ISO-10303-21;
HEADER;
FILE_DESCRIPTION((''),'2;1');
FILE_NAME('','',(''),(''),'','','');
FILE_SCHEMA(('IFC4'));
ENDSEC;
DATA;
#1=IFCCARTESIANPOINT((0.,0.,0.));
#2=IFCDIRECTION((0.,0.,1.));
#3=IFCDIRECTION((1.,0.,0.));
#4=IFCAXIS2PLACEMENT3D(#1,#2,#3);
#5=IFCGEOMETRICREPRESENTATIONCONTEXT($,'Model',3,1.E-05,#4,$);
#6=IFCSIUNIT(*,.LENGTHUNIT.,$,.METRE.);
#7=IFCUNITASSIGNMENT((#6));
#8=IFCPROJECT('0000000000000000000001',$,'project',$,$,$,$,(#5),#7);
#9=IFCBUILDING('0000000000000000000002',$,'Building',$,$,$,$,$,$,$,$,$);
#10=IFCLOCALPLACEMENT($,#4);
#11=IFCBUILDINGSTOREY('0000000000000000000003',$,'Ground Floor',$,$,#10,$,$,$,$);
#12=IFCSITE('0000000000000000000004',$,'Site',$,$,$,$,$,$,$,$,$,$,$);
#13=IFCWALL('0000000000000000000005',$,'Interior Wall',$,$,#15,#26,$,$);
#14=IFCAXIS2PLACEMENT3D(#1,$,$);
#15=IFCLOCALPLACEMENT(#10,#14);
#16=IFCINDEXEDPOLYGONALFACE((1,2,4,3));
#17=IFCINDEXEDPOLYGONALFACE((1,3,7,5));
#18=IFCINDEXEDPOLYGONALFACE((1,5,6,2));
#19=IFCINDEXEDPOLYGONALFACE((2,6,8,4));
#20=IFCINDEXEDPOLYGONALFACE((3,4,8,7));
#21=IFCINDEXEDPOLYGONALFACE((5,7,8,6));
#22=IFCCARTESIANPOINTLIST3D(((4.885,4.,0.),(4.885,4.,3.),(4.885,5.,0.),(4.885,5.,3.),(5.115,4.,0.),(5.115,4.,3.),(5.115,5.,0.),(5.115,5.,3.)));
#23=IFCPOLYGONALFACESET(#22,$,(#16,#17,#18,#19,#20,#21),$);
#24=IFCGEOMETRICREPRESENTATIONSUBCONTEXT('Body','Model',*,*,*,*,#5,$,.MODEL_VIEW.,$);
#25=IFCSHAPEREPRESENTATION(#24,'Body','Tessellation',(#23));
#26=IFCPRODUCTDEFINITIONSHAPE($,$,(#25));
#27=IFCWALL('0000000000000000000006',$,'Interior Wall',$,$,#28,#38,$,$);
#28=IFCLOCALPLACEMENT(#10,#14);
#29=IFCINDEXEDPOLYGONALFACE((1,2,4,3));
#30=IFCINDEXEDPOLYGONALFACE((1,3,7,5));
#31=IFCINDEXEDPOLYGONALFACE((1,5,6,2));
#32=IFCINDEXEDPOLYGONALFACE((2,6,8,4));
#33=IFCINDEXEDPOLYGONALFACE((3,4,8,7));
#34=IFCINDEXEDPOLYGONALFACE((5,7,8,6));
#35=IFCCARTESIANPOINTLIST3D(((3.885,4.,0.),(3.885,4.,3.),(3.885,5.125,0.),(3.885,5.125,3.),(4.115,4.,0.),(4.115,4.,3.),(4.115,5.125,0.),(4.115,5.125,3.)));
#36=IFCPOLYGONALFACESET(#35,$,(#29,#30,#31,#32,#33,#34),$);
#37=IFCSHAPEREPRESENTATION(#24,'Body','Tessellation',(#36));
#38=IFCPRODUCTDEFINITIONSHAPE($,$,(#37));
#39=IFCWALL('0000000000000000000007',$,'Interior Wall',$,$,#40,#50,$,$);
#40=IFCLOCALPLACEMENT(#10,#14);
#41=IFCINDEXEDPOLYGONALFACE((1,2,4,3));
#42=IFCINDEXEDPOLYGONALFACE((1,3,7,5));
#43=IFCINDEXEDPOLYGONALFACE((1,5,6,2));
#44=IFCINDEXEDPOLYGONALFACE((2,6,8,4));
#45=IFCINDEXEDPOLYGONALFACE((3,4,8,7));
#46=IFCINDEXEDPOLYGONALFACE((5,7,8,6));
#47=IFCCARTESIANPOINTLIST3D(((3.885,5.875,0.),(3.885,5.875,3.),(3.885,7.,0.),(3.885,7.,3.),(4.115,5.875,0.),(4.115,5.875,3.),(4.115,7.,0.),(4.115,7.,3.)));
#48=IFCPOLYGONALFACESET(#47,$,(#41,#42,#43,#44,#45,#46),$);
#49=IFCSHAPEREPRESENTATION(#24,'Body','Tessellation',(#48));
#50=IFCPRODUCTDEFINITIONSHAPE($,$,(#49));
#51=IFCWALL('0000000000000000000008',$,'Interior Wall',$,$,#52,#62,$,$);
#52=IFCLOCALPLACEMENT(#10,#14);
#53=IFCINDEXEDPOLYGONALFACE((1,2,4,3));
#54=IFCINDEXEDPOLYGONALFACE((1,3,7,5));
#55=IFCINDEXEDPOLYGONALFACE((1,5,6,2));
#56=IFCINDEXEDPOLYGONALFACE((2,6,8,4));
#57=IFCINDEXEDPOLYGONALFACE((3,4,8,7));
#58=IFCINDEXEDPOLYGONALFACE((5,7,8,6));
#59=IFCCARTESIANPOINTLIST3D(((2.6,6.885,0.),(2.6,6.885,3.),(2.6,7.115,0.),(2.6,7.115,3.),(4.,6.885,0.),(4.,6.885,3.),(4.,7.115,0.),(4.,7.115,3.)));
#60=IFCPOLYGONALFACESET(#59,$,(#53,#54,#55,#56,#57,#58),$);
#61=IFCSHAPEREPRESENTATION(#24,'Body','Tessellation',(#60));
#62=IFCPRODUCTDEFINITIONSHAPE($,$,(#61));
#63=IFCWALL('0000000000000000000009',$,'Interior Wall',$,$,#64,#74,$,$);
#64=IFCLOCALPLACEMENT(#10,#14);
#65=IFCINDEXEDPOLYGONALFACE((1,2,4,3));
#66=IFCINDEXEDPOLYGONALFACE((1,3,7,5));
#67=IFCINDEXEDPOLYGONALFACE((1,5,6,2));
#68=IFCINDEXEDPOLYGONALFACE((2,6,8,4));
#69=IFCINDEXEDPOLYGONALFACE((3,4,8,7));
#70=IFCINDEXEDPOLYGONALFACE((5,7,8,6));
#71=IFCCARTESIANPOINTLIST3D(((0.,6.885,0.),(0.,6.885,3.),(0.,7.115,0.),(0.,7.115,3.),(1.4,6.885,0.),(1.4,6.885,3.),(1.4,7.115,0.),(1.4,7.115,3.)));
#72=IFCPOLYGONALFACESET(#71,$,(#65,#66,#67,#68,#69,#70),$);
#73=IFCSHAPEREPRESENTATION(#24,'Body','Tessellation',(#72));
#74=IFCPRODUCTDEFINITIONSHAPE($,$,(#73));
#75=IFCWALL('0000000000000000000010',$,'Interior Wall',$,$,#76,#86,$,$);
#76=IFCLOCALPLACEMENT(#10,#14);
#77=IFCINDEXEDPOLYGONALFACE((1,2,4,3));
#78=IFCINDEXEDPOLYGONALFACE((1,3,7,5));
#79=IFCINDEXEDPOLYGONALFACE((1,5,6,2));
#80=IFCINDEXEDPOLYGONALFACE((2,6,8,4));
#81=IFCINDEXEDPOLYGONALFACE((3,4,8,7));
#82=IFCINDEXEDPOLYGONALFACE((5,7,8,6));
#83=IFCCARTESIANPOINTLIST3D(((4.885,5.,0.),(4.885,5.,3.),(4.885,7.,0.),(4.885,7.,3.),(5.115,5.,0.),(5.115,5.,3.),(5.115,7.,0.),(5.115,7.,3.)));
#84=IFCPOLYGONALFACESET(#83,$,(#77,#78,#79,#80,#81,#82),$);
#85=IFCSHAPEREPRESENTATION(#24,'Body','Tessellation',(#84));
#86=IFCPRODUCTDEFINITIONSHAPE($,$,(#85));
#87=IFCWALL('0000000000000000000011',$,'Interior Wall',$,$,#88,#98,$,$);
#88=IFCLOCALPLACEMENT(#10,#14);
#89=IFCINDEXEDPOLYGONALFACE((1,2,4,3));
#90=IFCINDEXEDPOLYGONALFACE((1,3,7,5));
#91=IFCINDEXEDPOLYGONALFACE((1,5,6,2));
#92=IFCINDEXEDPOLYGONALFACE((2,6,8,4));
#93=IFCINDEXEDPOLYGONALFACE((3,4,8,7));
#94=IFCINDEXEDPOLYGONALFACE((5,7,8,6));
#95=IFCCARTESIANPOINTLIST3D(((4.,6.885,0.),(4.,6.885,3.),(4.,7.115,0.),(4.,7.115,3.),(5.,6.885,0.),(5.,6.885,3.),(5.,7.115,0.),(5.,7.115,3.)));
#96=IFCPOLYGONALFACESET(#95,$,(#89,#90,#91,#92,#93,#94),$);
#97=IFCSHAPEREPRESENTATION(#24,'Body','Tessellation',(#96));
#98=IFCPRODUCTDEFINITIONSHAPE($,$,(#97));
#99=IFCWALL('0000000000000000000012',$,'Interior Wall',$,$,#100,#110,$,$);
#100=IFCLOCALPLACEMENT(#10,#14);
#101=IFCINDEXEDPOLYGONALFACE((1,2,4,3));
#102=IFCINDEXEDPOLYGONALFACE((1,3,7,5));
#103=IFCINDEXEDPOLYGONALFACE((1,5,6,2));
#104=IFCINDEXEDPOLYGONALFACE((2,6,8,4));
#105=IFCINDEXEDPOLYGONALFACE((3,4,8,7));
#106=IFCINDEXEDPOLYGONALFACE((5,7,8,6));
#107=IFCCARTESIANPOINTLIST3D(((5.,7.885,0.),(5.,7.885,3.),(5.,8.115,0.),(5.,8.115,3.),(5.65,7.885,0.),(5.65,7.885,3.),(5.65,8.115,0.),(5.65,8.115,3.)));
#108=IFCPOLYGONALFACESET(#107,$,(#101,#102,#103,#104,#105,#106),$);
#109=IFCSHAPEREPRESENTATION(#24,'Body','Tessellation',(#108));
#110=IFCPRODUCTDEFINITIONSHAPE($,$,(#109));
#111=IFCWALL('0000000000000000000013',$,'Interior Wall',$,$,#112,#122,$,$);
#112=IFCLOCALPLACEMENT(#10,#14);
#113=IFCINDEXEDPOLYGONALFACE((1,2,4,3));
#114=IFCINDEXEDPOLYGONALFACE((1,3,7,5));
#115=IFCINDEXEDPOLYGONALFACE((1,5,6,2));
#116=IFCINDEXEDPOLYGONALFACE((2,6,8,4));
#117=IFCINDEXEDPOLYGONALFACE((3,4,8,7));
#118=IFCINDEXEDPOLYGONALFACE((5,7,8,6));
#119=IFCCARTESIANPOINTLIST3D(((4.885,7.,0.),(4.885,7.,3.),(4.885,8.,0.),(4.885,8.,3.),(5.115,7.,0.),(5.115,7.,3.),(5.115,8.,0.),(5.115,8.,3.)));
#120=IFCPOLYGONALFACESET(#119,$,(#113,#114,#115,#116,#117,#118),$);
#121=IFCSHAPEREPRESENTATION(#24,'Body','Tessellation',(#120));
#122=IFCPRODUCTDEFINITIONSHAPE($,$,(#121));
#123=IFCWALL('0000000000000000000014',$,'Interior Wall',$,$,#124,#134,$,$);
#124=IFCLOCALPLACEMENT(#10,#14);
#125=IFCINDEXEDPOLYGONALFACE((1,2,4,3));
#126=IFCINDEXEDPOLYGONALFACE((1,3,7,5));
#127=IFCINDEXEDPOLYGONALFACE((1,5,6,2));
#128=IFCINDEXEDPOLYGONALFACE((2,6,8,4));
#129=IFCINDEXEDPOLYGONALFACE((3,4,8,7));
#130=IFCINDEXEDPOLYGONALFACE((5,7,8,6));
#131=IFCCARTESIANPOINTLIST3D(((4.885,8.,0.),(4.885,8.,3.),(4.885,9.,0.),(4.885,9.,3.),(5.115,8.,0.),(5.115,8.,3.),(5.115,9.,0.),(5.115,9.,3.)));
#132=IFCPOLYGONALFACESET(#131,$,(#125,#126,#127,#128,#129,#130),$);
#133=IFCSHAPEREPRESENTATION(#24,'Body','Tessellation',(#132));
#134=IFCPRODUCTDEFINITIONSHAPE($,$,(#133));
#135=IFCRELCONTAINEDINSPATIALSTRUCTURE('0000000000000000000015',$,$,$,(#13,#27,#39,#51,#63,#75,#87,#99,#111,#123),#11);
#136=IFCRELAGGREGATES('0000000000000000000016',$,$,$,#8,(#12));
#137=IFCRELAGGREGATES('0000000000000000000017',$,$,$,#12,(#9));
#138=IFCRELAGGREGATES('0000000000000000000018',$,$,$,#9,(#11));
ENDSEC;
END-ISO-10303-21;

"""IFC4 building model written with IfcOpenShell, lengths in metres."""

from ifc_helpers import new_model, si_unit, frame, origin_with_axes, place, context, subcontext, project, spatial, indexed_curve, outline, extrude, element, save


model = new_model("IFC4")

# Units and contexts
model_context = context("Model", 3, precision=1e-05, world=origin_with_axes())
body_context = subcontext(model_context, "Body", "Model", "MODEL_VIEW")
ifc_project = project(units=[si_unit("LENGTHUNIT", "METRE")], contexts=[model_context])

# Site, building, storey
site = spatial("IfcSite", under=ifc_project, Name="Site")
building = spatial("IfcBuilding", under=site, Name="Building")
storey_placement = place(None, origin_with_axes())
storey = spatial("IfcBuildingStorey", under=building, at=storey_placement, Name="Ground Floor")

# Walls
wall_1_placement = place(storey_placement, frame((5.0, 5.0, 0.0), z_axis=(0.0, 0.0, 1.0), x_axis=(0.0, -1.0, 0.0)))
element("IfcWall", 1, at=wall_1_placement, inside=storey, Name="Interior Wall", context=body_context, shape_type="SweptSolid", body=[
    extrude(outline(indexed_curve([(0.0, 0.0), (0.0, 0.23), (1.0, 0.23), (1.0, 0.0), (0.0, 0.0)], self_intersect=False)), frame((0.0, -0.115, 0.0), z_axis=(0.0, 0.0, 1.0), x_axis=(1.0, 0.0, 0.0)), (0.0, 0.0, 1.0), 3.0),
])
for number, where, z_axis, x_axis, name in (
    (2, (4.0, 4.0, 0.0), (0.0, 0.0, 1.0), (0.0, 1.0, 0.0), "Interior Wall"),
    (3, (4.0, 5.875, 0.0), (0.0, 0.0, 1.0), (0.0, 1.0, 0.0), "Interior Wall"),
):
    element("IfcWall", number, at=place(storey_placement, frame(where, z_axis=z_axis, x_axis=x_axis)), inside=storey, Name=name, context=body_context, shape_type="SweptSolid", body=[
        extrude(outline(indexed_curve([(0.0, 0.0), (0.0, 0.23), (1.125, 0.23), (1.125, 0.0), (0.0, 0.0)], self_intersect=False)), frame((0.0, -0.115, 0.0), z_axis=(0.0, 0.0, 1.0), x_axis=(1.0, 0.0, 0.0)), (0.0, 0.0, 1.0), 3.0),
    ])
for number, where, z_axis, x_axis, name in (
    (4, (4.0, 7.0, 0.0), (0.0, 0.0, 1.0), (-1.0, 0.0, 0.0), "Interior Wall"),
    (5, (1.4, 7.0, 0.0), (0.0, 0.0, 1.0), (-1.0, 0.0, 0.0), "Interior Wall"),
):
    element("IfcWall", number, at=place(storey_placement, frame(where, z_axis=z_axis, x_axis=x_axis)), inside=storey, Name=name, context=body_context, shape_type="SweptSolid", body=[
        extrude(outline(indexed_curve([(0.0, 0.0), (0.0, 0.23), (1.4, 0.23), (1.4, 0.0), (0.0, 0.0)], self_intersect=False)), frame((0.0, -0.115, 0.0), z_axis=(0.0, 0.0, 1.0), x_axis=(1.0, 0.0, 0.0)), (0.0, 0.0, 1.0), 3.0),
    ])
wall_2_placement = place(storey_placement, frame((5.0, 5.0, 0.0), z_axis=(0.0, 0.0, 1.0), x_axis=(0.0, 1.0, 0.0)))
element("IfcWall", 6, at=wall_2_placement, inside=storey, Name="Interior Wall", context=body_context, shape_type="SweptSolid", body=[
    extrude(outline(indexed_curve([(0.0, 0.0), (0.0, 0.23), (2.0, 0.23), (2.0, 0.0), (0.0, 0.0)], self_intersect=False)), frame((0.0, -0.115, 0.0), z_axis=(0.0, 0.0, 1.0), x_axis=(1.0, 0.0, 0.0)), (0.0, 0.0, 1.0), 3.0),
])
wall_3_placement = place(storey_placement, frame((5.0, 7.0, 0.0), z_axis=(0.0, 0.0, 1.0), x_axis=(-1.0, 0.0, 0.0)))
element("IfcWall", 7, at=wall_3_placement, inside=storey, Name="Interior Wall", context=body_context, shape_type="SweptSolid", body=[
    extrude(outline(indexed_curve([(0.0, 0.0), (0.0, 0.23), (1.0, 0.23), (1.0, 0.0), (0.0, 0.0)], self_intersect=False)), frame((0.0, -0.115, 0.0), z_axis=(0.0, 0.0, 1.0), x_axis=(1.0, 0.0, 0.0)), (0.0, 0.0, 1.0), 3.0),
])
wall_4_placement = place(storey_placement, frame((5.65, 8.0, 0.0), z_axis=(0.0, 0.0, 1.0), x_axis=(-1.0, 0.0, 0.0)))
element("IfcWall", 8, at=wall_4_placement, inside=storey, Name="Interior Wall", context=body_context, shape_type="SweptSolid", body=[
    extrude(outline(indexed_curve([(0.0, 0.0), (0.0, 0.23), (0.65, 0.23), (0.65, 0.0), (0.0, 0.0)], self_intersect=False)), frame((0.0, -0.115, 0.0), z_axis=(0.0, 0.0, 1.0), x_axis=(1.0, 0.0, 0.0)), (0.0, 0.0, 1.0), 3.0),
])
for number, where, z_axis, x_axis, name in (
    (9, (5.0, 8.0, 0.0), (0.0, 0.0, 1.0), (0.0, -1.0, 0.0), "Interior Wall"),
    (10, (5.0, 9.0, 0.0), (0.0, 0.0, 1.0), (0.0, -1.0, 0.0), "Interior Wall"),
):
    element("IfcWall", number, at=place(storey_placement, frame(where, z_axis=z_axis, x_axis=x_axis)), inside=storey, Name=name, context=body_context, shape_type="SweptSolid", body=[
        extrude(outline(indexed_curve([(0.0, 0.0), (0.0, 0.23), (1.0, 0.23), (1.0, 0.0), (0.0, 0.0)], self_intersect=False)), frame((0.0, -0.115, 0.0), z_axis=(0.0, 0.0, 1.0), x_axis=(1.0, 0.0, 0.0)), (0.0, 0.0, 1.0), 3.0),
    ])

save(model, "model.ifc")
